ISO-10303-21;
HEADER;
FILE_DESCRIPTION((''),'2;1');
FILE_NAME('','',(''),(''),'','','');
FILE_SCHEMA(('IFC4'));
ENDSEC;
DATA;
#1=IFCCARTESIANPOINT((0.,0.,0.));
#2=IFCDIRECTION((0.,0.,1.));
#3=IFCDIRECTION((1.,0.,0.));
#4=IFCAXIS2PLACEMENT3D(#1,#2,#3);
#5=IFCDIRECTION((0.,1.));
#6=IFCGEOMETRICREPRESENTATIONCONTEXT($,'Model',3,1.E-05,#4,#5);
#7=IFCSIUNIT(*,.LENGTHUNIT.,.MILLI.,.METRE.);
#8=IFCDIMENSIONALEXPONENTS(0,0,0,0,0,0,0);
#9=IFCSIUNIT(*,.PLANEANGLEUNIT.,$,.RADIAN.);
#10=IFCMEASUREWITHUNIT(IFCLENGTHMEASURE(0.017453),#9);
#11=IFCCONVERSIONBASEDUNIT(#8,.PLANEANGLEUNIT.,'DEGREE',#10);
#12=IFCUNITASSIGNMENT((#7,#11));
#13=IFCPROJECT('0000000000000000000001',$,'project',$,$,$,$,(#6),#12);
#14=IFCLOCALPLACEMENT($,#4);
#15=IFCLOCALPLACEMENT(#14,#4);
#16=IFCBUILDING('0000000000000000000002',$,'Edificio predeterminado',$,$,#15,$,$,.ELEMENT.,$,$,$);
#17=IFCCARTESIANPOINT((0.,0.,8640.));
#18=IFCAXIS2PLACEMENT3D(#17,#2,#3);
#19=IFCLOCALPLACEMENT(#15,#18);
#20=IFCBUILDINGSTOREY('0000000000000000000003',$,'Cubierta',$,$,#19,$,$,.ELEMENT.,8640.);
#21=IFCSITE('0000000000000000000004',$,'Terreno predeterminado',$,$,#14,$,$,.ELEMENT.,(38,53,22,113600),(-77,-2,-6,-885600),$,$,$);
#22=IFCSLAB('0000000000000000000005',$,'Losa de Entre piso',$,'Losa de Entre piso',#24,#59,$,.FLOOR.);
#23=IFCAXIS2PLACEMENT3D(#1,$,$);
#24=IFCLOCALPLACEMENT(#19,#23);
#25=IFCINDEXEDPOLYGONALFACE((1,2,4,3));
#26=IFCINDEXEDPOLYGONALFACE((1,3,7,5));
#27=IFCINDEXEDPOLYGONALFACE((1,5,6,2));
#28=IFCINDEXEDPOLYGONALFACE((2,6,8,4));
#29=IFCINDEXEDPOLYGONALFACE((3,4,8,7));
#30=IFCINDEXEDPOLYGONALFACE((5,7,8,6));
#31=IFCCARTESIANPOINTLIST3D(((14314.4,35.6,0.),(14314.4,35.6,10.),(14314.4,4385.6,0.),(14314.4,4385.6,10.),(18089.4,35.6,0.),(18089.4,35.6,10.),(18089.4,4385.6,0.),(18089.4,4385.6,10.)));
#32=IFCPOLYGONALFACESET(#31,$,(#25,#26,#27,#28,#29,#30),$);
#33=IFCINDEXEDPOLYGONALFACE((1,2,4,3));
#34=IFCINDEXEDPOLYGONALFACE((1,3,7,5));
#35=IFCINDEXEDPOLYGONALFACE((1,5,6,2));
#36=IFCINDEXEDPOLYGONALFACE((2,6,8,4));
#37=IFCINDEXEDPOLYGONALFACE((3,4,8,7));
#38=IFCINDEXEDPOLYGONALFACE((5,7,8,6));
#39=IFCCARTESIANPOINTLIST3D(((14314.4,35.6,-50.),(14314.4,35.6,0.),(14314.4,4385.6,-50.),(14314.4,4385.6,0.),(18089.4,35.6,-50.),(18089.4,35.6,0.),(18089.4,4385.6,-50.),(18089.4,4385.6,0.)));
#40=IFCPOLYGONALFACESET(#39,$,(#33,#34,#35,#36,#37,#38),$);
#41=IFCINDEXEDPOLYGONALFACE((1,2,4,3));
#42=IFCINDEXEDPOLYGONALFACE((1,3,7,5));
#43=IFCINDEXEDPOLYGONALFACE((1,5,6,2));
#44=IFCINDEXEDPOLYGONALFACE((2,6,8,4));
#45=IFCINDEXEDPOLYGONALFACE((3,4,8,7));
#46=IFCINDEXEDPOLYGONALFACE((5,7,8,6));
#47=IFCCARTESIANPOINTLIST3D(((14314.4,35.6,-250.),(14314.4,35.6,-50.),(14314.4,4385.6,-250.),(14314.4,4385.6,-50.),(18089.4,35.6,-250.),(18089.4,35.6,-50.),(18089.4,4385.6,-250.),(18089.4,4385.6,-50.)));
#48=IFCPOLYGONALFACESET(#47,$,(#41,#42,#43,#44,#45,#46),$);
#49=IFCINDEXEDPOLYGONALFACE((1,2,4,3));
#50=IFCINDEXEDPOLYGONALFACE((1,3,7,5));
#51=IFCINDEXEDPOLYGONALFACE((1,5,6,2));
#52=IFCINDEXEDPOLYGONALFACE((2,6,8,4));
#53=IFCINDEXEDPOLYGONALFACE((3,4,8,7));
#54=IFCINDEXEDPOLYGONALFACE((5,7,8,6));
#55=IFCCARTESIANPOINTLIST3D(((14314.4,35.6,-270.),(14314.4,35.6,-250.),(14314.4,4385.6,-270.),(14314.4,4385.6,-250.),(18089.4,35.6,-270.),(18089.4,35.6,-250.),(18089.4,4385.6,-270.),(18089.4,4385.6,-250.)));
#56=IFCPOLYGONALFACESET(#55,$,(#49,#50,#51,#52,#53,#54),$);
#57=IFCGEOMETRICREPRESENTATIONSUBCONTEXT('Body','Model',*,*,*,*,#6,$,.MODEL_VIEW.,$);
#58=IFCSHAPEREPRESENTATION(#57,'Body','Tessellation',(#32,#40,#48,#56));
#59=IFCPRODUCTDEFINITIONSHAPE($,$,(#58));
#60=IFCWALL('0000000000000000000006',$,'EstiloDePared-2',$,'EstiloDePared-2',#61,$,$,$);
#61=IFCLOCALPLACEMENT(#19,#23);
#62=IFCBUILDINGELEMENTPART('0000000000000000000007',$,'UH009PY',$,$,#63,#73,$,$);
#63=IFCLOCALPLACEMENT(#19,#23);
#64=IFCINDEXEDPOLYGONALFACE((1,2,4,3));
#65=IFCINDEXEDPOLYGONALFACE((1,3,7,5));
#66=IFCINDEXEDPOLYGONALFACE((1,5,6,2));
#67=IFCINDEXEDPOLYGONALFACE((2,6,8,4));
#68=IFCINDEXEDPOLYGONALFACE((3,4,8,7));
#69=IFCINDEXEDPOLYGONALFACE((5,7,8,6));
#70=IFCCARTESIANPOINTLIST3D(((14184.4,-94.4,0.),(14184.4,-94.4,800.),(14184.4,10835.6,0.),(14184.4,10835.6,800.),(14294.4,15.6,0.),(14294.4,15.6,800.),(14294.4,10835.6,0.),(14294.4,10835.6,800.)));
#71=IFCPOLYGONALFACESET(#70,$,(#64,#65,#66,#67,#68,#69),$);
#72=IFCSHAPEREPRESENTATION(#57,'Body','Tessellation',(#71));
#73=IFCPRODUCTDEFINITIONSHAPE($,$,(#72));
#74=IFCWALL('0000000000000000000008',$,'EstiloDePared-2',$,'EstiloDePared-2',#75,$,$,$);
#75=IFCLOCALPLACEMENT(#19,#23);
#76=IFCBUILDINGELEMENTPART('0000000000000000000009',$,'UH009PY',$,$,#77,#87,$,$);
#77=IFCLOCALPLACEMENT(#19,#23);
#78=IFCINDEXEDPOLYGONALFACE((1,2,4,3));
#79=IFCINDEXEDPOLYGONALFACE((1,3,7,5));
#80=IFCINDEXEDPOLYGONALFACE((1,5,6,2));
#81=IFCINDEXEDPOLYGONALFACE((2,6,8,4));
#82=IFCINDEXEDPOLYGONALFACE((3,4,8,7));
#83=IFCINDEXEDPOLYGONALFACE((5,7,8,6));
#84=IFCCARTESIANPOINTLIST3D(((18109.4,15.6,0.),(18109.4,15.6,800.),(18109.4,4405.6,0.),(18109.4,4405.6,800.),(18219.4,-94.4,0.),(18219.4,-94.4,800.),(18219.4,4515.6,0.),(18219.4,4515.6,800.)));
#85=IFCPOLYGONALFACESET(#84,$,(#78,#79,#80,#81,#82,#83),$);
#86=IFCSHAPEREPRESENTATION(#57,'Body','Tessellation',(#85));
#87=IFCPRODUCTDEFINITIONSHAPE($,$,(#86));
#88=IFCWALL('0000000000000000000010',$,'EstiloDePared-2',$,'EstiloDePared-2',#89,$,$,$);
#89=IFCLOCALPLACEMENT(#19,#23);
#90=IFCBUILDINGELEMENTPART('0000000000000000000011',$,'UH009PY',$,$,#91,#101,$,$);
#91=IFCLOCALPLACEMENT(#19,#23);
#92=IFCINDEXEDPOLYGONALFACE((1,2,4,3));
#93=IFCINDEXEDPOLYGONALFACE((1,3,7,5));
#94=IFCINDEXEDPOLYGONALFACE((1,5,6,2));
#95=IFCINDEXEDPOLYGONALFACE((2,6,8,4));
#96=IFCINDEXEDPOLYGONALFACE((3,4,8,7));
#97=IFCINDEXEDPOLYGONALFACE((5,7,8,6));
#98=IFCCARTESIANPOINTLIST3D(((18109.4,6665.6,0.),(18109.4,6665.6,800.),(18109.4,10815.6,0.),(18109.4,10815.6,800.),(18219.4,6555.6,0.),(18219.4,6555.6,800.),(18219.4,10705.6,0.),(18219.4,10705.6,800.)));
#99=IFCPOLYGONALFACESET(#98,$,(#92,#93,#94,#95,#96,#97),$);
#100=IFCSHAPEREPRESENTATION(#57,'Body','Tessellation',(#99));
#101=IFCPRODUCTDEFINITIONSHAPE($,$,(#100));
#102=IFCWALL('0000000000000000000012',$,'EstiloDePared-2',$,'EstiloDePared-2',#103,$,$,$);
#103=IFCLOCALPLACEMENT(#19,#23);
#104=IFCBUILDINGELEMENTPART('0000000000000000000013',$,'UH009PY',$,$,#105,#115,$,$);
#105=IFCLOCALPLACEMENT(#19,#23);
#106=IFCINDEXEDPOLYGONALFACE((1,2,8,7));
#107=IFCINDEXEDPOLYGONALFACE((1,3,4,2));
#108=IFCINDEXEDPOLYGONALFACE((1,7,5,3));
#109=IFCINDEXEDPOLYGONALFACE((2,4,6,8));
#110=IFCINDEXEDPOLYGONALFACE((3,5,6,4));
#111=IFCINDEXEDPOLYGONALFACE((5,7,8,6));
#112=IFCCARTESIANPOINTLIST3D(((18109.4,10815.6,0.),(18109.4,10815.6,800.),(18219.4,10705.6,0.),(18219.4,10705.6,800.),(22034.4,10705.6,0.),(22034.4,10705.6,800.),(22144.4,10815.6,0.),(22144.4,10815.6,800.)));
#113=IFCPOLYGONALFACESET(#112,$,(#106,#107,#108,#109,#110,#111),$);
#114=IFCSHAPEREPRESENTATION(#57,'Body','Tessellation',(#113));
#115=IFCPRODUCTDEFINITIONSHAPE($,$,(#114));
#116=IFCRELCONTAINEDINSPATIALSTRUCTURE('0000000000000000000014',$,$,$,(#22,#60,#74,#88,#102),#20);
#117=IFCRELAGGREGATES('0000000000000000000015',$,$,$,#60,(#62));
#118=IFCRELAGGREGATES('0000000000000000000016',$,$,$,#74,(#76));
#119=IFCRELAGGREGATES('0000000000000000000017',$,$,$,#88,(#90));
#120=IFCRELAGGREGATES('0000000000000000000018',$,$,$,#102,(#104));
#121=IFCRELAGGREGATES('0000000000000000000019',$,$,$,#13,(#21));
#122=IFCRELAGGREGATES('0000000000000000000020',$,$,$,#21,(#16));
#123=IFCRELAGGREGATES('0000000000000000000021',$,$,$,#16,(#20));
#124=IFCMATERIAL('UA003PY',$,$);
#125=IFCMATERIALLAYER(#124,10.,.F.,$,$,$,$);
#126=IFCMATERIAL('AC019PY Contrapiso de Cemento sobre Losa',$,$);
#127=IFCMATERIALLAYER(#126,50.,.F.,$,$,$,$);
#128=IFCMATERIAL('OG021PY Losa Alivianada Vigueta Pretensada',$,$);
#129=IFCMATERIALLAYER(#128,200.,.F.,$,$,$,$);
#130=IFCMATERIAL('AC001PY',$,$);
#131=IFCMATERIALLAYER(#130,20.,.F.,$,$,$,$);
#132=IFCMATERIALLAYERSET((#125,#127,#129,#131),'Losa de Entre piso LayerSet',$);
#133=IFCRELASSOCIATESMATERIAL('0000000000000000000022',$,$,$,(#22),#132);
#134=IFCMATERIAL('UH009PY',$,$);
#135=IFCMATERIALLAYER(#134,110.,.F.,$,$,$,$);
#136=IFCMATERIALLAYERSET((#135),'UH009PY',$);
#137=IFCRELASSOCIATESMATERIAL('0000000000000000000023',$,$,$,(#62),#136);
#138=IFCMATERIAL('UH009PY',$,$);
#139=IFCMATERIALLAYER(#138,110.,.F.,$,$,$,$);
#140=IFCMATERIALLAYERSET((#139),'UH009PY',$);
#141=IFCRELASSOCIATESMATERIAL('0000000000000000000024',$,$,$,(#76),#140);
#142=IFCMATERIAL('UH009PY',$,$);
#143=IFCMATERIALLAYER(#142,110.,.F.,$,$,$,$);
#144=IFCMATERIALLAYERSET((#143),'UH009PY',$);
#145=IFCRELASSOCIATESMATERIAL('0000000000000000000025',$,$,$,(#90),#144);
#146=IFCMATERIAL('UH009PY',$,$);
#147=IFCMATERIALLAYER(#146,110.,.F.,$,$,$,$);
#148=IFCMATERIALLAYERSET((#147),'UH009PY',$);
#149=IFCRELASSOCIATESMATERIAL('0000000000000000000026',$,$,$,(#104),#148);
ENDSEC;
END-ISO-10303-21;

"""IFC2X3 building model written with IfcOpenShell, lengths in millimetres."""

from ifc_helpers import new_model, entity, si_unit, converted_unit, direction, frame, origin_with_axes, place, context, subcontext, project, spatial, polyline, outline, extrude, material, layer, layer_set, layer_usage, element, aggregate, save


model = new_model("IFC2X3")

# Units and contexts
model_context = context("Model", 3, precision=1e-05, world=origin_with_axes(), true_north=direction((0.0, 1.0)))
body_context = subcontext(model_context, "Body", "Model", "MODEL_VIEW")
ifc_project = project(units=[si_unit("LENGTHUNIT", "METRE", prefix="MILLI"), converted_unit("PLANEANGLEUNIT", "DEGREE", entity("IfcLengthMeasure", 0.017453), si_unit("PLANEANGLEUNIT", "RADIAN"), dimensions=[0, 0, 0, 0, 0, 0, 0])], contexts=[model_context])

# Site, building, storey
site_placement = place(None, origin_with_axes())
site = spatial("IfcSite", under=ifc_project, at=site_placement, Name="Terreno predeterminado", CompositionType="ELEMENT", RefLatitude=(38, 53, 22, 113600), RefLongitude=(-77, -2, -6, -885600))
building_placement = place(site_placement, origin_with_axes())
building = spatial("IfcBuilding", under=site, at=building_placement, Name="Edificio predeterminado", CompositionType="ELEMENT")
storey_placement = place(building_placement, frame((0.0, 0.0, 8640.0), z_axis=(0.0, 0.0, 1.0), x_axis=(1.0, 0.0, 0.0)))
storey = spatial("IfcBuildingStorey", under=building, at=storey_placement, Name="Cubierta", CompositionType="ELEMENT", Elevation=8640.0)

# Slab
ifc_material_1 = material(Name="UA003PY")
ifc_layer_1 = layer(ifc_material_1, 10.0, ventilated=False)
ifc_material_2 = material(Name="AC019PY Contrapiso de Cemento sobre Losa")
ifc_layer_2 = layer(ifc_material_2, 50.0, ventilated=False)
ifc_material_3 = material(Name="OG021PY Losa Alivianada Vigueta Pretensada")
ifc_layer_3 = layer(ifc_material_3, 200.0, ventilated=False)
ifc_material_4 = material(Name="AC001PY")
ifc_layer_4 = layer(ifc_material_4, 20.0, ventilated=False)
ifc_layer_set_1 = layer_set([ifc_layer_1, ifc_layer_2, ifc_layer_3, ifc_layer_4], Name="Losa de Entre piso LayerSet")
ifc_layer_usage_1 = layer_usage(ifc_layer_set_1, "AXIS3", "NEGATIVE", 0.0)
slab_1_placement = place(storey_placement, frame((0.0, 0.0, -8640.0), z_axis=(0.0, 0.0, 1.0), x_axis=(1.0, 0.0, 0.0)))
element("IfcSlab", 1, at=slab_1_placement, inside=storey, material=ifc_layer_usage_1, Name="Losa de Entre piso", ObjectType="Losa de Entre piso", PredefinedType="FLOOR", context=body_context, shape_type="SweptSolid", body=[
    extrude(outline(polyline([(0.0, 4350.0), (3775.0, 4350.0), (3775.0, 0.0), (0.0, 0.0), (0.0, 4350.0)])), frame((18089.4, 35.6, 8640.0), z_axis=(0.0, 0.0, -1.0), x_axis=(-1.0, 0.0, 0.0)), (0.0, 0.0, -1.0), 10.0),
    extrude(outline(polyline([(0.0, 4350.0), (3775.0, 4350.0), (3775.0, 0.0), (0.0, 0.0), (0.0, 4350.0)])), frame((18089.4, 35.6, 8590.0), z_axis=(0.0, 0.0, -1.0), x_axis=(-1.0, 0.0, 0.0)), (0.0, 0.0, -1.0), 50.0),
    extrude(outline(polyline([(0.0, 4350.0), (3775.0, 4350.0), (3775.0, 0.0), (0.0, 0.0), (0.0, 4350.0)])), frame((18089.4, 35.6, 8390.0), z_axis=(0.0, 0.0, -1.0), x_axis=(-1.0, 0.0, 0.0)), (0.0, 0.0, -1.0), 200.0),
    extrude(outline(polyline([(0.0, 4350.0), (3775.0, 4350.0), (3775.0, 0.0), (0.0, 0.0), (0.0, 4350.0)])), frame((18089.4, 35.6, 8370.0), z_axis=(0.0, 0.0, -1.0), x_axis=(-1.0, 0.0, 0.0)), (0.0, 0.0, -1.0), 20.0),
])

# Walls, building element parts
wall_1_placement = place(storey_placement, frame((14239.4, -39.4, 0.0), z_axis=(0.0, 0.0, 1.0), x_axis=(0.0, 1.0, 0.0)))
wall_1 = element("IfcWall", 2, at=wall_1_placement, inside=storey, Name="EstiloDePared-2", ObjectType="EstiloDePared-2")
ifc_material_5 = material(Name="UH009PY")
ifc_layer_5 = layer(ifc_material_5, 110.0, ventilated=False)
ifc_layer_set_2 = layer_set([ifc_layer_5], Name="UH009PY")
ifc_layer_usage_2 = layer_usage(ifc_layer_set_2, "AXIS2", "NEGATIVE", -55.0)
building_element_part_1_placement = place(wall_1_placement, origin_with_axes())
building_element_part_1 = element("IfcBuildingElementPart", 3, at=building_element_part_1_placement, material=ifc_layer_usage_2, Name="UH009PY", context=body_context, shape_type="SweptSolid", body=[
    extrude(outline(polyline([(10875.0, 55.0), (10875.0, -55.0), (55.0, -55.0), (-55.0, 55.0), (10875.0, 55.0)])), origin_with_axes(), (0.0, 0.0, 1.0), 800.0),
])
aggregate(wall_1, [building_element_part_1])
wall_2_placement = place(storey_placement, frame((18164.4, -39.4, 0.0), z_axis=(0.0, 0.0, 1.0), x_axis=(0.0, 1.0, 0.0)))
wall_2 = element("IfcWall", 4, at=wall_2_placement, inside=storey, Name="EstiloDePared-2", ObjectType="EstiloDePared-2")
ifc_material_6 = material(Name="UH009PY")
ifc_layer_6 = layer(ifc_material_6, 110.0, ventilated=False)
ifc_layer_set_3 = layer_set([ifc_layer_6], Name="UH009PY")
ifc_layer_usage_3 = layer_usage(ifc_layer_set_3, "AXIS2", "NEGATIVE", -55.0)
building_element_part_2_placement = place(wall_2_placement, origin_with_axes())
building_element_part_2 = element("IfcBuildingElementPart", 5, at=building_element_part_2_placement, material=ifc_layer_usage_3, Name="UH009PY", context=body_context, shape_type="SweptSolid", body=[
    extrude(outline(polyline([(4445.0, 55.0), (4555.0, -55.0), (-55.0, -55.0), (55.0, 55.0), (4445.0, 55.0)])), origin_with_axes(), (0.0, 0.0, 1.0), 800.0),
])
aggregate(wall_2, [building_element_part_2])
wall_3_placement = place(storey_placement, frame((18164.4, 6610.6, 0.0), z_axis=(0.0, 0.0, 1.0), x_axis=(0.0, 1.0, 0.0)))
wall_3 = element("IfcWall", 6, at=wall_3_placement, inside=storey, Name="EstiloDePared-2", ObjectType="EstiloDePared-2")
ifc_material_7 = material(Name="UH009PY")
ifc_layer_7 = layer(ifc_material_7, 110.0, ventilated=False)
ifc_layer_set_4 = layer_set([ifc_layer_7], Name="UH009PY")
ifc_layer_usage_4 = layer_usage(ifc_layer_set_4, "AXIS2", "NEGATIVE", -55.0)
building_element_part_3_placement = place(wall_3_placement, origin_with_axes())
building_element_part_3 = element("IfcBuildingElementPart", 7, at=building_element_part_3_placement, material=ifc_layer_usage_4, Name="UH009PY", context=body_context, shape_type="SweptSolid", body=[
    extrude(outline(polyline([(4205.0, 55.0), (4095.0, -55.0), (-55.0, -55.0), (55.0, 55.0), (4205.0, 55.0)])), origin_with_axes(), (0.0, 0.0, 1.0), 800.0),
])
aggregate(wall_3, [building_element_part_3])
wall_4_placement = place(storey_placement, frame((18164.4, 10760.6, 0.0), z_axis=(0.0, 0.0, 1.0), x_axis=(1.0, 0.0, 0.0)))
wall_4 = element("IfcWall", 8, at=wall_4_placement, inside=storey, Name="EstiloDePared-2", ObjectType="EstiloDePared-2")
ifc_material_8 = material(Name="UH009PY")
ifc_layer_8 = layer(ifc_material_8, 110.0, ventilated=False)
ifc_layer_set_5 = layer_set([ifc_layer_8], Name="UH009PY")
ifc_layer_usage_5 = layer_usage(ifc_layer_set_5, "AXIS2", "NEGATIVE", -55.0)
building_element_part_4_placement = place(wall_4_placement, origin_with_axes())
building_element_part_4 = element("IfcBuildingElementPart", 9, at=building_element_part_4_placement, material=ifc_layer_usage_5, Name="UH009PY", context=body_context, shape_type="SweptSolid", body=[
    extrude(outline(polyline([(3980.0, 55.0), (3870.0, -55.0), (55.0, -55.0), (-55.0, 55.0), (3980.0, 55.0)])), origin_with_axes(), (0.0, 0.0, 1.0), 800.0),
])
aggregate(wall_4, [building_element_part_4])

save(model, "model.ifc")
